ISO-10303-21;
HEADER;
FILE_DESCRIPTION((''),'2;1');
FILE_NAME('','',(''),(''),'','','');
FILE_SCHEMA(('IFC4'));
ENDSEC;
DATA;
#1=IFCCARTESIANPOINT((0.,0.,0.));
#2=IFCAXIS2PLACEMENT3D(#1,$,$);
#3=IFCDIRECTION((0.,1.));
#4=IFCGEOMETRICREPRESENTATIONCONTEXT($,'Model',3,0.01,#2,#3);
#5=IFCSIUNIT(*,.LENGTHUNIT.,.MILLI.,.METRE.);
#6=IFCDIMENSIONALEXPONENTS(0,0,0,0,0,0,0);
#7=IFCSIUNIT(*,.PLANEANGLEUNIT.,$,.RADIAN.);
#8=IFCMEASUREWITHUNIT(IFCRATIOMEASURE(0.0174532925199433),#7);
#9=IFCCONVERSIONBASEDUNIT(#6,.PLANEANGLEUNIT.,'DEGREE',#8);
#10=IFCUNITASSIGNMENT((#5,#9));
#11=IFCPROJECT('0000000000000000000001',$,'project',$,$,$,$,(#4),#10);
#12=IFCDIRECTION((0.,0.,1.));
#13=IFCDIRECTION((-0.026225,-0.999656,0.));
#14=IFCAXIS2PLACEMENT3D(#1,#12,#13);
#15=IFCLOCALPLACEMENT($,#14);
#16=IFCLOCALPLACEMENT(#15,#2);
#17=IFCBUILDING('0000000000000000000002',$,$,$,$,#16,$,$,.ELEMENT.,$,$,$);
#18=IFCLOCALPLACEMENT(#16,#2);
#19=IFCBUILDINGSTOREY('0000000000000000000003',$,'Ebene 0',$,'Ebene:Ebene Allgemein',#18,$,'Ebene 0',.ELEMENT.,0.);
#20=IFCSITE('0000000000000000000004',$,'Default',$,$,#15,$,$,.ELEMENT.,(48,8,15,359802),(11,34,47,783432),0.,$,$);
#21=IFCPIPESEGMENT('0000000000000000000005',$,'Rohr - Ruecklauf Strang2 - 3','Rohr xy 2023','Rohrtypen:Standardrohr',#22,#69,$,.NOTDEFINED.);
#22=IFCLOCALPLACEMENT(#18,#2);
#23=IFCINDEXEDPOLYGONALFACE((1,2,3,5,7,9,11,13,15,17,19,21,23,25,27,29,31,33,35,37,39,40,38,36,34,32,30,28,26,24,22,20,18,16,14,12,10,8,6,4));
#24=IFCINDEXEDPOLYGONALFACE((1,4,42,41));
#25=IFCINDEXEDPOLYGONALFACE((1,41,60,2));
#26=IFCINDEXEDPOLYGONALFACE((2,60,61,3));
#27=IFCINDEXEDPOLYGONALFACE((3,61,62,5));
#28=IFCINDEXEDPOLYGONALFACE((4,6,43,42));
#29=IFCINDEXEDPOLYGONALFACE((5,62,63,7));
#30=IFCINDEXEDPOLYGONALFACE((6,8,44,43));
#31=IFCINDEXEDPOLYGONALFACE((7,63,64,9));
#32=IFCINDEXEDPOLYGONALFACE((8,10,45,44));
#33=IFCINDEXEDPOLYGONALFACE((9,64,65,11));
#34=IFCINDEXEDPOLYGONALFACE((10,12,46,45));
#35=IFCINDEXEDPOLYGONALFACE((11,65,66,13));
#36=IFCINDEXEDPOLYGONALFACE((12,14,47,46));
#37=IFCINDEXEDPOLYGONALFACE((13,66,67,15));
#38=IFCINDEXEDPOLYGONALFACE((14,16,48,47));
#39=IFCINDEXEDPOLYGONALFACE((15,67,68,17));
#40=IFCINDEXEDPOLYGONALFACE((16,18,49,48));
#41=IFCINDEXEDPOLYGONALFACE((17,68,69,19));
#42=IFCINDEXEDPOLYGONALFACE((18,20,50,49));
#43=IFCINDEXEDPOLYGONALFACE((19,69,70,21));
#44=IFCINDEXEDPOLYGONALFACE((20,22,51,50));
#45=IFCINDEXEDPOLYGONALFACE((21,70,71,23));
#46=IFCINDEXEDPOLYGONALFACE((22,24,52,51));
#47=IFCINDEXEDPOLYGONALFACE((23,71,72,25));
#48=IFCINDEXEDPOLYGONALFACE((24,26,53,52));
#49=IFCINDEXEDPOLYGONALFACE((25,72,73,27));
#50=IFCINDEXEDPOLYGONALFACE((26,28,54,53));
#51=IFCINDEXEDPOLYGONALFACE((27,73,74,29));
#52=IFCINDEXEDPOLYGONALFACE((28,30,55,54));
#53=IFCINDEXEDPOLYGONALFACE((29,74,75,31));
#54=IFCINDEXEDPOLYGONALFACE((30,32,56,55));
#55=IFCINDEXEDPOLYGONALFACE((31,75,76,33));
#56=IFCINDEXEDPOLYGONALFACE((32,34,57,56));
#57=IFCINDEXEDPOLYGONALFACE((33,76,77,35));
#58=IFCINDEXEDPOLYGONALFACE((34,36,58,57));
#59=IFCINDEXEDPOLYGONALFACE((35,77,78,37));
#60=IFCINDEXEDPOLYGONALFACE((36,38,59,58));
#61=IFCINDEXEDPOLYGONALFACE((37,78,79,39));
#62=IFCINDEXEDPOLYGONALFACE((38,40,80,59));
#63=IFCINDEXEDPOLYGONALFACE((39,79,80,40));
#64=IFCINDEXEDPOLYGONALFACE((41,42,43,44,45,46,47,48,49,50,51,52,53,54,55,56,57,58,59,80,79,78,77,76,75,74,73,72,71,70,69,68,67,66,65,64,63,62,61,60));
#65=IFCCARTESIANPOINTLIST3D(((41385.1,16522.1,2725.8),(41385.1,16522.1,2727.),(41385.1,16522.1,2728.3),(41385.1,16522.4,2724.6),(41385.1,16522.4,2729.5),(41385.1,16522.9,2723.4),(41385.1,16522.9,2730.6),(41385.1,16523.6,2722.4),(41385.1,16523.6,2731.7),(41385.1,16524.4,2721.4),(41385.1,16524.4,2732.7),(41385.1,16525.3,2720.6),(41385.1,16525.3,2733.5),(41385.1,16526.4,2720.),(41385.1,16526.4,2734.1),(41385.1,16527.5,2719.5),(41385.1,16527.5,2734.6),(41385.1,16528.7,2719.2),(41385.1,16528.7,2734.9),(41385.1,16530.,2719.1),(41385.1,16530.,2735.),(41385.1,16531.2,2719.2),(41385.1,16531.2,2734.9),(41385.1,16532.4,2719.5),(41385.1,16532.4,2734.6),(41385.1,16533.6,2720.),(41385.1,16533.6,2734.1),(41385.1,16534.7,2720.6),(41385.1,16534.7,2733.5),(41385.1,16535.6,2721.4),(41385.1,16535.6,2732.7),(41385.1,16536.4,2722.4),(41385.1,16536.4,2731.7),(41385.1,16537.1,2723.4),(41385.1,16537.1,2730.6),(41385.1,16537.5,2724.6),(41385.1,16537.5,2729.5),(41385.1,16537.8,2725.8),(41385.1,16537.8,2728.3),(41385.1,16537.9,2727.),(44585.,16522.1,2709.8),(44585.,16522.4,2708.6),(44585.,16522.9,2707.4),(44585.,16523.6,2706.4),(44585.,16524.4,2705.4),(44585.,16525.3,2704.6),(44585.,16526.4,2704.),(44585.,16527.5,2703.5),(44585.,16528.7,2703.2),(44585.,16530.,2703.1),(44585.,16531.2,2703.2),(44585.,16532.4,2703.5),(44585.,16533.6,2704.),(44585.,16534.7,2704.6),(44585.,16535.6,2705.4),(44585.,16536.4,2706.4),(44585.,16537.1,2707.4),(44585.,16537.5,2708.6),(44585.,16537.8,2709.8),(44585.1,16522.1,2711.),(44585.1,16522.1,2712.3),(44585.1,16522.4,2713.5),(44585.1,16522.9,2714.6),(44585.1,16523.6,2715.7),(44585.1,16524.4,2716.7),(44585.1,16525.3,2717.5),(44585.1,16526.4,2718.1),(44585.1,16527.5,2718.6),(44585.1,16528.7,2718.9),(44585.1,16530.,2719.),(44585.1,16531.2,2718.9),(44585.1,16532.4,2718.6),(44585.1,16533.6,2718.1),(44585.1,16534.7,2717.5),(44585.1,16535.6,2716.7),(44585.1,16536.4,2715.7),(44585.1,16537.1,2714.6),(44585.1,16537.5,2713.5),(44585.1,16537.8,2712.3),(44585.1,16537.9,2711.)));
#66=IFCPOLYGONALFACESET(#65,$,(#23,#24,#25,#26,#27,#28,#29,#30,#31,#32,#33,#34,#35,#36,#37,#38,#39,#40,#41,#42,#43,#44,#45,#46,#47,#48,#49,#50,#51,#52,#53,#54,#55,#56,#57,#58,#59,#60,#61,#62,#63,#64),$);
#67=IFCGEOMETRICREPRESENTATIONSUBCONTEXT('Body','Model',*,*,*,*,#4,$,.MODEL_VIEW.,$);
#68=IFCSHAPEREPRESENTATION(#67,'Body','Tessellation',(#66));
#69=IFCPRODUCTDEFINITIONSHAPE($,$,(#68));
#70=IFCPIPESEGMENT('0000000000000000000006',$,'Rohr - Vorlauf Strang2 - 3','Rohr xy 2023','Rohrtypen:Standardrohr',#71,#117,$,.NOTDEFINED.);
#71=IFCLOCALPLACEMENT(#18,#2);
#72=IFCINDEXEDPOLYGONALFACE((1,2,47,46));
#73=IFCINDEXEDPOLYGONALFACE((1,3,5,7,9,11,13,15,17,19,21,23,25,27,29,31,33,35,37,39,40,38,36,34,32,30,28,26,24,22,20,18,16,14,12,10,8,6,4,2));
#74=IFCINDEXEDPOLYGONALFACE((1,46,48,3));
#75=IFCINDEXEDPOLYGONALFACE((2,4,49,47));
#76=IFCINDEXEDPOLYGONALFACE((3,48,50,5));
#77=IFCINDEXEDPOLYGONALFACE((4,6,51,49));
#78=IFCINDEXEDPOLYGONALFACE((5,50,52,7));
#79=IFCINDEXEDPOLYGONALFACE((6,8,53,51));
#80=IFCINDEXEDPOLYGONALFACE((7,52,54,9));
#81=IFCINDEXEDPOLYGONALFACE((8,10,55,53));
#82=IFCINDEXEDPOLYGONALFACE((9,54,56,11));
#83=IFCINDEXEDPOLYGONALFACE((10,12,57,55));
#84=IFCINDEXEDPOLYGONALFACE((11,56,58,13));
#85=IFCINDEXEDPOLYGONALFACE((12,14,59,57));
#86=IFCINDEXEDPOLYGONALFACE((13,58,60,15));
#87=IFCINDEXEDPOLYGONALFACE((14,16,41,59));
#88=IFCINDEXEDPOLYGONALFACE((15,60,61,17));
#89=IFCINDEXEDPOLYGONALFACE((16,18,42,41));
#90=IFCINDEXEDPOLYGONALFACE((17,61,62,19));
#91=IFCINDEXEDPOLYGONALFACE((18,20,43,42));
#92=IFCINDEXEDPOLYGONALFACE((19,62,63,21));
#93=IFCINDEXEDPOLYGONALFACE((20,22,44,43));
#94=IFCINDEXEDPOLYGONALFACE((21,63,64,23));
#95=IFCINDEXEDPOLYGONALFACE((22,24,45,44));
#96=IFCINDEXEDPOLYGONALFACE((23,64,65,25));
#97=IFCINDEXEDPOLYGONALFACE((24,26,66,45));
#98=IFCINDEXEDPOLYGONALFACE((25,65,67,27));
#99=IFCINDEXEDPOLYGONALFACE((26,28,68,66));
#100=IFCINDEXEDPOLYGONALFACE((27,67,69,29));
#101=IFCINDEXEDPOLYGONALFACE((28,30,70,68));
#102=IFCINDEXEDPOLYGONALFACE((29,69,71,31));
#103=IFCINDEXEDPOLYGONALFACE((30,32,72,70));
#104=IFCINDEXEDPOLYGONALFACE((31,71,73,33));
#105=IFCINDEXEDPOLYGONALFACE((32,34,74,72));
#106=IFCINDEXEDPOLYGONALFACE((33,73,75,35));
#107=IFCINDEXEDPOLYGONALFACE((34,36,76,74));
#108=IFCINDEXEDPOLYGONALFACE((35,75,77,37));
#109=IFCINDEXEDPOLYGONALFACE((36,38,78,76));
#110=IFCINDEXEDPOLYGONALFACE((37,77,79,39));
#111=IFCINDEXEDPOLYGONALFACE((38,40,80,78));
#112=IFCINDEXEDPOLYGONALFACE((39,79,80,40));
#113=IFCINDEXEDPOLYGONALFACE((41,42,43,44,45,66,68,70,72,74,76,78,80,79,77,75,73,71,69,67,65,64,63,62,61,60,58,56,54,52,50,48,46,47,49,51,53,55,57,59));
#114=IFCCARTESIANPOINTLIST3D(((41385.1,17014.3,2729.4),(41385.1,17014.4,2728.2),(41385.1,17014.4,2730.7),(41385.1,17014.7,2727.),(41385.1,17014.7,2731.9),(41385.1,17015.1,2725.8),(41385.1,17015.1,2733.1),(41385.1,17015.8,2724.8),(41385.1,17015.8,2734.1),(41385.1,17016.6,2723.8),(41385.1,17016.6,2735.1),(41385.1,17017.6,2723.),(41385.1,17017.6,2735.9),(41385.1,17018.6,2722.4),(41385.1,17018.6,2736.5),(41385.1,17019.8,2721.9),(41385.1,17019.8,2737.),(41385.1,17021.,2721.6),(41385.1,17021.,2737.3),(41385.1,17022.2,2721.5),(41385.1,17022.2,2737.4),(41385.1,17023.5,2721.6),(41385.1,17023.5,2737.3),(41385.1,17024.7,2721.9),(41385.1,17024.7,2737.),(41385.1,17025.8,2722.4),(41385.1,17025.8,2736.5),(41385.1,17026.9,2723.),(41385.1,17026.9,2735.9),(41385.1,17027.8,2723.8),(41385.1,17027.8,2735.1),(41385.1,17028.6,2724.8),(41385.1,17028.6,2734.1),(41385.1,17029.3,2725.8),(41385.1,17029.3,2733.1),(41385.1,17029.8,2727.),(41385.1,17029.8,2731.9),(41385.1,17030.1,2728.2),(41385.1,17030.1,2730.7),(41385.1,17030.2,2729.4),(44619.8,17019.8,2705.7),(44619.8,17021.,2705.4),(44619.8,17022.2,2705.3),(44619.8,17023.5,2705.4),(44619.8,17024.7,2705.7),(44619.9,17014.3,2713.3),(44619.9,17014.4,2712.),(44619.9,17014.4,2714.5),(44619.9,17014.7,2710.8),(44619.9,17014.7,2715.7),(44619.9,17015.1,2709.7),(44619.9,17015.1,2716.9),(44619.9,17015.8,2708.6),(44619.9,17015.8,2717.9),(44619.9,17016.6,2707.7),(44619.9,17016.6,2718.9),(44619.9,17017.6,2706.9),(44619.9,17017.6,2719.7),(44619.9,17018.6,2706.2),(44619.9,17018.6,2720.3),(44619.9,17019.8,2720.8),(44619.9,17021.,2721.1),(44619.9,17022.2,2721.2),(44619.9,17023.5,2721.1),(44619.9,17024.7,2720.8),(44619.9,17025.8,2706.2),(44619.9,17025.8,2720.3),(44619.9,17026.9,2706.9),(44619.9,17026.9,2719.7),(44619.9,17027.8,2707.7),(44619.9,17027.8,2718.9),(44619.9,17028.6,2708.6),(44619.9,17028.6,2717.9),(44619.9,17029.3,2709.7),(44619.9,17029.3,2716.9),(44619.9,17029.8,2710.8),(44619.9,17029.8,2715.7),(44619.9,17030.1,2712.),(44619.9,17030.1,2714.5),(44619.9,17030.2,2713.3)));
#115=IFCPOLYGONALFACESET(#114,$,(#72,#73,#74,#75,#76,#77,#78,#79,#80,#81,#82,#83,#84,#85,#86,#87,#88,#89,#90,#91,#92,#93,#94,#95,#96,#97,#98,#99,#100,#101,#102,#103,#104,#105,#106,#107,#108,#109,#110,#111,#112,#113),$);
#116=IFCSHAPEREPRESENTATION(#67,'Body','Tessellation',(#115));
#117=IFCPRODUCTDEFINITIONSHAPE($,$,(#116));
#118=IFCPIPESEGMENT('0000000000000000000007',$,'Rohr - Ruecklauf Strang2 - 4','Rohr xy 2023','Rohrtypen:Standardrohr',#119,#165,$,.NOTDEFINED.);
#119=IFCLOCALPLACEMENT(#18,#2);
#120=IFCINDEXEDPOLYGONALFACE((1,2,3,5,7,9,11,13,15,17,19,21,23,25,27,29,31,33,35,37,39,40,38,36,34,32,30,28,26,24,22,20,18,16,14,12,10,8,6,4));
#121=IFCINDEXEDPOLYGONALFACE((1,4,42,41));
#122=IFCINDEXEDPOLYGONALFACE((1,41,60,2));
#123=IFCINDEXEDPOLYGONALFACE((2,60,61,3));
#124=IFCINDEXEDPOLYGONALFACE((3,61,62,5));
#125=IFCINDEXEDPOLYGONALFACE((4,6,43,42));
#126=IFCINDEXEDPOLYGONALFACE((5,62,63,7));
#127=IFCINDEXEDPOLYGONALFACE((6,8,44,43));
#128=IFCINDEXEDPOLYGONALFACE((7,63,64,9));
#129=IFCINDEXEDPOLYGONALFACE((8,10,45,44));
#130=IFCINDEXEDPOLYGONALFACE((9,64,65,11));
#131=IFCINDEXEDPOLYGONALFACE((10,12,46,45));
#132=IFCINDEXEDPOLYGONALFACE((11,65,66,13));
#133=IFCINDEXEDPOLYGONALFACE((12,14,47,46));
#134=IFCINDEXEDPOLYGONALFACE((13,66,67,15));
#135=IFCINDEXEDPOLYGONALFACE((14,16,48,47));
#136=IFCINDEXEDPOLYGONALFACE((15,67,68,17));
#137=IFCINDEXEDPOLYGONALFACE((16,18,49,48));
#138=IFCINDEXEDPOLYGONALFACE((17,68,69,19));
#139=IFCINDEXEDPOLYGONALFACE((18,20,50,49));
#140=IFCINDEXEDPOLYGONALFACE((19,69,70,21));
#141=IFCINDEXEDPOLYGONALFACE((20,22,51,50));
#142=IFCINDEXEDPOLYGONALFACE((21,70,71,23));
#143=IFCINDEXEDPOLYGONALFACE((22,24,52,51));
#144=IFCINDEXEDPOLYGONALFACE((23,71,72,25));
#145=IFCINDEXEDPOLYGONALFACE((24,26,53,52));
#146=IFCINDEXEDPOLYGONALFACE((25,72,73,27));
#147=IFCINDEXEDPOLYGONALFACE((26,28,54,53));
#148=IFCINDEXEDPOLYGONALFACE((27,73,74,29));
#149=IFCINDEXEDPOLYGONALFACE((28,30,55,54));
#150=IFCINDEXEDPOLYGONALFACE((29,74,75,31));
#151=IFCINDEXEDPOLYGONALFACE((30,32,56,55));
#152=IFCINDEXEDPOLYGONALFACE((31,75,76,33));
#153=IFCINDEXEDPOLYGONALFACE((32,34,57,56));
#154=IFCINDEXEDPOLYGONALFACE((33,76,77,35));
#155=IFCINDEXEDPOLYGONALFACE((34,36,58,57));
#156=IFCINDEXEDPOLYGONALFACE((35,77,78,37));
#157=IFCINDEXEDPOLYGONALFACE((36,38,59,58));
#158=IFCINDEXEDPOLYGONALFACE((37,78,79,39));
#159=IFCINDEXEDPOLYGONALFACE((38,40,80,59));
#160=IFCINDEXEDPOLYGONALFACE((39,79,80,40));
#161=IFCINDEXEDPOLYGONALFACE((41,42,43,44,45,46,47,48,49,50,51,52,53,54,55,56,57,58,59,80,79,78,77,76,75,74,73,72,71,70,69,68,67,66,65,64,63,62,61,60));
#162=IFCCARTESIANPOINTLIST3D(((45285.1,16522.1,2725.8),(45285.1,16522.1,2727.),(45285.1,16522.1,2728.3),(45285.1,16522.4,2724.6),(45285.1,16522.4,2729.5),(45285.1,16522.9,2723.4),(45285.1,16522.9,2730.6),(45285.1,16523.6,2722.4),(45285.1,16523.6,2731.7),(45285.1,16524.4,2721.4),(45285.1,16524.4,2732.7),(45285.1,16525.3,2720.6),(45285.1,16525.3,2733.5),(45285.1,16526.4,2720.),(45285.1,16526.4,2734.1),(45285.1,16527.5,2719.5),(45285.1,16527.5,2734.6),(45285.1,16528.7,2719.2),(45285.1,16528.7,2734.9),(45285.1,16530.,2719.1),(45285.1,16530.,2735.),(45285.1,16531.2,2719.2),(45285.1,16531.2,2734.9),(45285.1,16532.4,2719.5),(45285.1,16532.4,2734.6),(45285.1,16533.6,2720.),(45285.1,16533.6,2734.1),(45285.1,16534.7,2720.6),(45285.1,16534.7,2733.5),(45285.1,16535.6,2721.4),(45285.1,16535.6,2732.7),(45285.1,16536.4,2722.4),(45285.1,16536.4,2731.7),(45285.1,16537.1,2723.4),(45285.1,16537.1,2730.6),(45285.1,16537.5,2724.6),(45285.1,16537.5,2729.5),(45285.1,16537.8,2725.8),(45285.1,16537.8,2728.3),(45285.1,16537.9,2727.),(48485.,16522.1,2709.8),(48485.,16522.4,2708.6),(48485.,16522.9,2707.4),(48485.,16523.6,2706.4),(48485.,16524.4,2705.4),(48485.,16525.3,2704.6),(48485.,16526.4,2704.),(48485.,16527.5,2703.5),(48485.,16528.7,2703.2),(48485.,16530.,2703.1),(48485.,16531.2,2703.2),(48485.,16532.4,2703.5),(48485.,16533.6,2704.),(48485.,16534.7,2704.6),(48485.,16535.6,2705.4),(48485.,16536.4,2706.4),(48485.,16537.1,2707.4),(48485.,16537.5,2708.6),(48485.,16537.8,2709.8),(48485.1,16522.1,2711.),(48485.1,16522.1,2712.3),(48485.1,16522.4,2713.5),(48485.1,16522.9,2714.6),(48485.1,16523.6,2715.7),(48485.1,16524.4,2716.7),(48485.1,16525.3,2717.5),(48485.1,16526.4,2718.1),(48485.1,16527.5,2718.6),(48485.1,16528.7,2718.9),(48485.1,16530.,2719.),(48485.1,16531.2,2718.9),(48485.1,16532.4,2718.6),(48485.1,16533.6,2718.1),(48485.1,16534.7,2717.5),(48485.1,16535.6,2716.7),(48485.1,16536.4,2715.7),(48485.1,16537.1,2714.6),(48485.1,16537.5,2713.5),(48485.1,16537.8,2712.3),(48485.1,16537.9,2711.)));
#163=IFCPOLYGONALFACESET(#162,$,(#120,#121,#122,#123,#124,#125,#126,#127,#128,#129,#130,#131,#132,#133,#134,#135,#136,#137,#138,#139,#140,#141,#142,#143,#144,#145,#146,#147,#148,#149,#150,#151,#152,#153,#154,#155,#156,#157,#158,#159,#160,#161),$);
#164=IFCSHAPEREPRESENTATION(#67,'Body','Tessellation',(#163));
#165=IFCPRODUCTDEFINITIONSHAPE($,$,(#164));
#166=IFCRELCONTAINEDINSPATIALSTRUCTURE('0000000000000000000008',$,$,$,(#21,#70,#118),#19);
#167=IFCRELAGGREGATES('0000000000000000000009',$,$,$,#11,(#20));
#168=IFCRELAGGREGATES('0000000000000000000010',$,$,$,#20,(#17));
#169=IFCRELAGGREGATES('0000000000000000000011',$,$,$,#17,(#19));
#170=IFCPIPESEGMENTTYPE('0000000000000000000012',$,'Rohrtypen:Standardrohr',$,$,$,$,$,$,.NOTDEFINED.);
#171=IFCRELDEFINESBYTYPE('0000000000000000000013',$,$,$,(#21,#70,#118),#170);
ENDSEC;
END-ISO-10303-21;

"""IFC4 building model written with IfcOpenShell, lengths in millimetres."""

from ifc_helpers import new_model, entity, si_unit, converted_unit, direction, frame, origin, place, context, subcontext, project, spatial, indexed_curve, outline, extrude, type_object, element, save


model = new_model("IFC4")

# Units and contexts
model_context = context("Model", 3, precision=0.01, world=origin(), true_north=direction((0.0, 1.0)))
body_context = subcontext(model_context, "Body", "Model", "MODEL_VIEW")
ifc_project = project(units=[si_unit("LENGTHUNIT", "METRE", prefix="MILLI"), converted_unit("PLANEANGLEUNIT", "DEGREE", entity("IfcRatioMeasure", 0.0174532925199433), si_unit("PLANEANGLEUNIT", "RADIAN"), dimensions=[0, 0, 0, 0, 0, 0, 0])], contexts=[model_context])

# Site, building, storey
site_placement = place(None, frame((0.0, 0.0, 0.0), z_axis=(0.0, 0.0, 1.0), x_axis=(-0.026225, -0.999656, 0.0)))
site = spatial("IfcSite", under=ifc_project, at=site_placement, Name="Default", CompositionType="ELEMENT", RefLatitude=(48, 8, 15, 359802), RefLongitude=(11, 34, 47, 783432), RefElevation=0.0)
building_placement = place(site_placement, origin())
building = spatial("IfcBuilding", under=site, at=building_placement, CompositionType="ELEMENT")
storey_placement = place(building_placement, origin())
storey = spatial("IfcBuildingStorey", under=building, at=storey_placement, Name="Ebene 0", ObjectType="Ebene:Ebene Allgemein", LongName="Ebene 0", CompositionType="ELEMENT", Elevation=0.0)

# Pipe segments
pipe_segment_type = type_object("IfcPipeSegmentType", Name="Rohrtypen:Standardrohr", PredefinedType="NOTDEFINED")
pipe_segment_1_placement = place(storey_placement, origin())
element("IfcPipeSegment", 1, at=pipe_segment_1_placement, inside=storey, type_object=pipe_segment_type, Name="Rohr - Ruecklauf Strang2 - 3", Description="Rohr xy 2023", ObjectType="Rohrtypen:Standardrohr", PredefinedType="NOTDEFINED", context=body_context, shape_type="SweptSolid", body=[
    extrude(outline(indexed_curve([(7.9, 0.0), (7.8, 1.2), (7.6, 2.5), (7.1, 3.6), (6.4, 4.7), (5.6, 5.6), (4.7, 6.4), (3.6, 7.1), (2.5, 7.6), (1.2, 7.8), (0.0, 7.9), (-1.2, 7.8), (-2.5, 7.6), (-3.6, 7.1), (-4.7, 6.4), (-5.6, 5.6), (-6.4, 4.7), (-7.1, 3.6), (-7.6, 2.5), (-7.8, 1.2), (-7.9, 0.0), (-7.8, -1.2), (-7.6, -2.5), (-7.1, -3.6), (-6.4, -4.7), (-5.6, -5.6), (-4.7, -6.4), (-3.6, -7.1), (-2.5, -7.6), (-1.2, -7.8), (0.0, -7.9), (1.2, -7.8), (2.5, -7.6), (3.6, -7.1), (4.7, -6.4), (5.6, -5.6), (6.4, -4.7), (7.1, -3.6), (7.6, -2.5), (7.8, -1.2), (7.9, 0.0)], self_intersect=False)), frame((44585.1, 16530.0, 2711.0), z_axis=(-0.999988, 0.0, 0.005), x_axis=(0.0, 1.0, 0.0)), (0.0, 0.0, 1.0), 3200.0),
])
pipe_segment_2_placement = place(storey_placement, origin())
element("IfcPipeSegment", 2, at=pipe_segment_2_placement, inside=storey, type_object=pipe_segment_type, Name="Rohr - Vorlauf Strang2 - 3", Description="Rohr xy 2023", ObjectType="Rohrtypen:Standardrohr", PredefinedType="NOTDEFINED", context=body_context, shape_type="SweptSolid", body=[
    extrude(outline(indexed_curve([(7.9, 0.0), (7.8, 1.2), (7.6, 2.5), (7.1, 3.6), (6.4, 4.7), (5.6, 5.6), (4.7, 6.4), (3.6, 7.1), (2.5, 7.6), (1.2, 7.8), (0.0, 7.9), (-1.2, 7.8), (-2.5, 7.6), (-3.6, 7.1), (-4.7, 6.4), (-5.6, 5.6), (-6.4, 4.7), (-7.1, 3.6), (-7.6, 2.5), (-7.8, 1.2), (-7.9, 0.0), (-7.8, -1.2), (-7.6, -2.5), (-7.1, -3.6), (-6.4, -4.7), (-5.6, -5.6), (-4.7, -6.4), (-3.6, -7.1), (-2.5, -7.6), (-1.2, -7.8), (0.0, -7.9), (1.2, -7.8), (2.5, -7.6), (3.6, -7.1), (4.7, -6.4), (5.6, -5.6), (6.4, -4.7), (7.1, -3.6), (7.6, -2.5), (7.8, -1.2), (7.9, 0.0)], self_intersect=False)), frame((44619.9, 17022.2, 2713.3), z_axis=(-0.999988, 0.0, 0.005), x_axis=(0.0, 1.0, 0.0)), (0.0, 0.0, 1.0), 3234.8),
])
pipe_segment_3_placement = place(storey_placement, origin())
element("IfcPipeSegment", 3, at=pipe_segment_3_placement, inside=storey, type_object=pipe_segment_type, Name="Rohr - Ruecklauf Strang2 - 4", Description="Rohr xy 2023", ObjectType="Rohrtypen:Standardrohr", PredefinedType="NOTDEFINED", context=body_context, shape_type="SweptSolid", body=[
    extrude(outline(indexed_curve([(7.9, 0.0), (7.8, 1.2), (7.6, 2.5), (7.1, 3.6), (6.4, 4.7), (5.6, 5.6), (4.7, 6.4), (3.6, 7.1), (2.5, 7.6), (1.2, 7.8), (0.0, 7.9), (-1.2, 7.8), (-2.5, 7.6), (-3.6, 7.1), (-4.7, 6.4), (-5.6, 5.6), (-6.4, 4.7), (-7.1, 3.6), (-7.6, 2.5), (-7.8, 1.2), (-7.9, 0.0), (-7.8, -1.2), (-7.6, -2.5), (-7.1, -3.6), (-6.4, -4.7), (-5.6, -5.6), (-4.7, -6.4), (-3.6, -7.1), (-2.5, -7.6), (-1.2, -7.8), (0.0, -7.9), (1.2, -7.8), (2.5, -7.6), (3.6, -7.1), (4.7, -6.4), (5.6, -5.6), (6.4, -4.7), (7.1, -3.6), (7.6, -2.5), (7.8, -1.2), (7.9, 0.0)], self_intersect=False)), frame((48485.1, 16530.0, 2711.0), z_axis=(-0.999988, 0.0, 0.005), x_axis=(0.0, 1.0, 0.0)), (0.0, 0.0, 1.0), 3200.0),
])

save(model, "model.ifc")
